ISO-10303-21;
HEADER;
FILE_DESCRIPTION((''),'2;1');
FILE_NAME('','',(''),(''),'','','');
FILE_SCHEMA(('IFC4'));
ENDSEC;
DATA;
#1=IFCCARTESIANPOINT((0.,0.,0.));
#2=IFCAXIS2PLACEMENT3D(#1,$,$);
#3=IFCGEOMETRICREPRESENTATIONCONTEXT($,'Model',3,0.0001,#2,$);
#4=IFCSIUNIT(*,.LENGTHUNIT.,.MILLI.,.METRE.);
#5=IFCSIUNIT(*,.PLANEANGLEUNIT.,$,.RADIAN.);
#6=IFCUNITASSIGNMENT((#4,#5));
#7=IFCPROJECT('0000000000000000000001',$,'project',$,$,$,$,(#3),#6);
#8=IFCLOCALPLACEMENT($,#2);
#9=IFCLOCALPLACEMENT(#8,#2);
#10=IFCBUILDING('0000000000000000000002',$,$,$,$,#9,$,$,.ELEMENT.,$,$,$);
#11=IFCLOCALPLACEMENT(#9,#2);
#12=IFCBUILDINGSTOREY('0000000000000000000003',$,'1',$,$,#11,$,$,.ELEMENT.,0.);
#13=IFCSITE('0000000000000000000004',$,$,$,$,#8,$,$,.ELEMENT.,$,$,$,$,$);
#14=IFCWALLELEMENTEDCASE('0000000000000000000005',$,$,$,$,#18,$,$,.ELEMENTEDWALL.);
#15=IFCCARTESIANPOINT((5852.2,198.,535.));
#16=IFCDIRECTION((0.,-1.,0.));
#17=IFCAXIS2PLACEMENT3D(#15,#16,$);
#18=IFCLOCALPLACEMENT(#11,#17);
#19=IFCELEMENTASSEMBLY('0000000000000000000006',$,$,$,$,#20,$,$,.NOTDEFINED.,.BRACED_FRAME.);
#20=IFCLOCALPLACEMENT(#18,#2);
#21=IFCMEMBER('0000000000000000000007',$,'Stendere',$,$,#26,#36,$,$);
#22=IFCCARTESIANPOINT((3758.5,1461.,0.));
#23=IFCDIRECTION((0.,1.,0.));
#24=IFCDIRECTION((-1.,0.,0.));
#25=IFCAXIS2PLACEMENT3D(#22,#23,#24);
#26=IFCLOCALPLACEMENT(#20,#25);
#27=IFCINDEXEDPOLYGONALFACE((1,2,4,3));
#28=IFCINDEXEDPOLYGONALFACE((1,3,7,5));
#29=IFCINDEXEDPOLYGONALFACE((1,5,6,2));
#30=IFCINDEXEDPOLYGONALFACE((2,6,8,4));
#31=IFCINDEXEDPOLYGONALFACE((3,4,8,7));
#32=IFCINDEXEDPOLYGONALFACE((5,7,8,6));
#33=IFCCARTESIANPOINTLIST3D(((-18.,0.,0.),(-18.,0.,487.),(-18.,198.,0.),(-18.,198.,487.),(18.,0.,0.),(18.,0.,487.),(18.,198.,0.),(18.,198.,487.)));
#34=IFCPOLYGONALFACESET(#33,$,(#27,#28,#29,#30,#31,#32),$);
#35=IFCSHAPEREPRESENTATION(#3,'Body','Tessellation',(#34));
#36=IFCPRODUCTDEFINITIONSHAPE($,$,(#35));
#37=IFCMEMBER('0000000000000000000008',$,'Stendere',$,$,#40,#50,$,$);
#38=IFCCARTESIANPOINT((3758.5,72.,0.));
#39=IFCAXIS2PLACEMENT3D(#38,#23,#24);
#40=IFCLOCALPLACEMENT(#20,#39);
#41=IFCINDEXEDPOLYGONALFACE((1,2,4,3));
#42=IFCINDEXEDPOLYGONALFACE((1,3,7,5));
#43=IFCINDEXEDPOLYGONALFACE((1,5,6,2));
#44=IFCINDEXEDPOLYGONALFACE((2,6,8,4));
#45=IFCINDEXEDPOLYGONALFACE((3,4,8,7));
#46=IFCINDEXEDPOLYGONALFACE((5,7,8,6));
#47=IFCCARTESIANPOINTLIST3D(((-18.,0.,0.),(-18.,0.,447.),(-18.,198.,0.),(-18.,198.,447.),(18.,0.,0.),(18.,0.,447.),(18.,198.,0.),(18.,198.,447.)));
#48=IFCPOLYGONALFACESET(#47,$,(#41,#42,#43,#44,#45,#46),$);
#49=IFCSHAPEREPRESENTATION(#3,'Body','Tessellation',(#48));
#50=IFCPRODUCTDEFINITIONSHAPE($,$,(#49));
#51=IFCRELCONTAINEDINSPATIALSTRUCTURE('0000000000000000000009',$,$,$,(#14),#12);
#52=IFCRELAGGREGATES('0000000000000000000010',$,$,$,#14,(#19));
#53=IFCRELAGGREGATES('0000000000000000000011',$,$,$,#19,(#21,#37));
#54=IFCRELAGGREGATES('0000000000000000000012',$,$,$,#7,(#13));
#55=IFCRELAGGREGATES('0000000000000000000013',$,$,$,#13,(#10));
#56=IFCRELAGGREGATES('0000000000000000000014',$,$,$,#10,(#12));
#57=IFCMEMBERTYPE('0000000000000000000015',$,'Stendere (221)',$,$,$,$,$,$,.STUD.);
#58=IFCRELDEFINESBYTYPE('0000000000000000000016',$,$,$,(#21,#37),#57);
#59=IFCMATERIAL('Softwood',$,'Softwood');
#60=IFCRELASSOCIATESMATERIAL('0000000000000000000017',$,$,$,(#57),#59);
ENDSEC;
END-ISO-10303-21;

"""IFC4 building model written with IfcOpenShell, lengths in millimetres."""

from ifc_helpers import new_model, si_unit, frame, origin, place, context, project, spatial, rectangle, extrude, material, material_profile, profile_set, type_object, element, aggregate, save


model = new_model("IFC4")

# Units and contexts
model_context = context("Model", 3, precision=0.0001, world=origin())
ifc_project = project(units=[si_unit("LENGTHUNIT", "METRE", prefix="MILLI"), si_unit("PLANEANGLEUNIT", "RADIAN")], contexts=[model_context])

# Site, building, storey
site_placement = place(None, origin())
site = spatial("IfcSite", under=ifc_project, at=site_placement, CompositionType="ELEMENT")
building_placement = place(site_placement, origin())
building = spatial("IfcBuilding", under=site, at=building_placement, CompositionType="ELEMENT")
storey_placement = place(building_placement, origin())
storey = spatial("IfcBuildingStorey", under=building, at=storey_placement, Name="1", CompositionType="ELEMENT", Elevation=0.0)

# Shared definitions
ifc_material_1 = material(Name="Softwood", Category="Softwood")
ifc_material_profile_1 = material_profile(ifc_material_1, rectangle(XDim=36.0, YDim=198.0), Name="Stendere (221)")
ifc_profile_set_1 = profile_set([ifc_material_profile_1])
member_type_1 = type_object("IfcMemberType", Name="Stendere (221)", PredefinedType="STUD", material=ifc_profile_set_1)

# Wall, element assembly, members
wall_1_placement = place(storey_placement, frame((5852.2, 198.0, 535.0), z_axis=(0.0, -1.0, 0.0)))
wall_1 = element("IfcWallElementedCase", 1, at=wall_1_placement, inside=storey, PredefinedType="ELEMENTEDWALL")
assembly_1_placement = place(wall_1_placement, origin())
assembly_1 = element("IfcElementAssembly", 2, at=assembly_1_placement, AssemblyPlace="NOTDEFINED", PredefinedType="BRACED_FRAME")
aggregate(wall_1, [assembly_1])
member_1_placement = place(assembly_1_placement, frame((3758.5, 1461.0, 0.0), z_axis=(0.0, 1.0, 0.0), x_axis=(-1.0, 0.0, 0.0)))
member_1 = element("IfcMember", 3, at=member_1_placement, type_object=member_type_1, Name="Stendere", context=model_context, shape_type="SweptSolid", body=[
    extrude(rectangle(XDim=36.0, YDim=198.0), frame((0.0, 99.0, 0.0)), (0.0, 0.0, 1.0), 487.0),
])
member_2_placement = place(assembly_1_placement, frame((3758.5, 72.0, 0.0), z_axis=(0.0, 1.0, 0.0), x_axis=(-1.0, 0.0, 0.0)))
member_2 = element("IfcMember", 4, at=member_2_placement, type_object=member_type_1, Name="Stendere", context=model_context, shape_type="SweptSolid", body=[
    extrude(rectangle(XDim=36.0, YDim=198.0), frame((0.0, 99.0, 0.0)), (0.0, 0.0, 1.0), 447.0),
])

aggregate(assembly_1, [member_1, member_2])

save(model, "model.ifc")
